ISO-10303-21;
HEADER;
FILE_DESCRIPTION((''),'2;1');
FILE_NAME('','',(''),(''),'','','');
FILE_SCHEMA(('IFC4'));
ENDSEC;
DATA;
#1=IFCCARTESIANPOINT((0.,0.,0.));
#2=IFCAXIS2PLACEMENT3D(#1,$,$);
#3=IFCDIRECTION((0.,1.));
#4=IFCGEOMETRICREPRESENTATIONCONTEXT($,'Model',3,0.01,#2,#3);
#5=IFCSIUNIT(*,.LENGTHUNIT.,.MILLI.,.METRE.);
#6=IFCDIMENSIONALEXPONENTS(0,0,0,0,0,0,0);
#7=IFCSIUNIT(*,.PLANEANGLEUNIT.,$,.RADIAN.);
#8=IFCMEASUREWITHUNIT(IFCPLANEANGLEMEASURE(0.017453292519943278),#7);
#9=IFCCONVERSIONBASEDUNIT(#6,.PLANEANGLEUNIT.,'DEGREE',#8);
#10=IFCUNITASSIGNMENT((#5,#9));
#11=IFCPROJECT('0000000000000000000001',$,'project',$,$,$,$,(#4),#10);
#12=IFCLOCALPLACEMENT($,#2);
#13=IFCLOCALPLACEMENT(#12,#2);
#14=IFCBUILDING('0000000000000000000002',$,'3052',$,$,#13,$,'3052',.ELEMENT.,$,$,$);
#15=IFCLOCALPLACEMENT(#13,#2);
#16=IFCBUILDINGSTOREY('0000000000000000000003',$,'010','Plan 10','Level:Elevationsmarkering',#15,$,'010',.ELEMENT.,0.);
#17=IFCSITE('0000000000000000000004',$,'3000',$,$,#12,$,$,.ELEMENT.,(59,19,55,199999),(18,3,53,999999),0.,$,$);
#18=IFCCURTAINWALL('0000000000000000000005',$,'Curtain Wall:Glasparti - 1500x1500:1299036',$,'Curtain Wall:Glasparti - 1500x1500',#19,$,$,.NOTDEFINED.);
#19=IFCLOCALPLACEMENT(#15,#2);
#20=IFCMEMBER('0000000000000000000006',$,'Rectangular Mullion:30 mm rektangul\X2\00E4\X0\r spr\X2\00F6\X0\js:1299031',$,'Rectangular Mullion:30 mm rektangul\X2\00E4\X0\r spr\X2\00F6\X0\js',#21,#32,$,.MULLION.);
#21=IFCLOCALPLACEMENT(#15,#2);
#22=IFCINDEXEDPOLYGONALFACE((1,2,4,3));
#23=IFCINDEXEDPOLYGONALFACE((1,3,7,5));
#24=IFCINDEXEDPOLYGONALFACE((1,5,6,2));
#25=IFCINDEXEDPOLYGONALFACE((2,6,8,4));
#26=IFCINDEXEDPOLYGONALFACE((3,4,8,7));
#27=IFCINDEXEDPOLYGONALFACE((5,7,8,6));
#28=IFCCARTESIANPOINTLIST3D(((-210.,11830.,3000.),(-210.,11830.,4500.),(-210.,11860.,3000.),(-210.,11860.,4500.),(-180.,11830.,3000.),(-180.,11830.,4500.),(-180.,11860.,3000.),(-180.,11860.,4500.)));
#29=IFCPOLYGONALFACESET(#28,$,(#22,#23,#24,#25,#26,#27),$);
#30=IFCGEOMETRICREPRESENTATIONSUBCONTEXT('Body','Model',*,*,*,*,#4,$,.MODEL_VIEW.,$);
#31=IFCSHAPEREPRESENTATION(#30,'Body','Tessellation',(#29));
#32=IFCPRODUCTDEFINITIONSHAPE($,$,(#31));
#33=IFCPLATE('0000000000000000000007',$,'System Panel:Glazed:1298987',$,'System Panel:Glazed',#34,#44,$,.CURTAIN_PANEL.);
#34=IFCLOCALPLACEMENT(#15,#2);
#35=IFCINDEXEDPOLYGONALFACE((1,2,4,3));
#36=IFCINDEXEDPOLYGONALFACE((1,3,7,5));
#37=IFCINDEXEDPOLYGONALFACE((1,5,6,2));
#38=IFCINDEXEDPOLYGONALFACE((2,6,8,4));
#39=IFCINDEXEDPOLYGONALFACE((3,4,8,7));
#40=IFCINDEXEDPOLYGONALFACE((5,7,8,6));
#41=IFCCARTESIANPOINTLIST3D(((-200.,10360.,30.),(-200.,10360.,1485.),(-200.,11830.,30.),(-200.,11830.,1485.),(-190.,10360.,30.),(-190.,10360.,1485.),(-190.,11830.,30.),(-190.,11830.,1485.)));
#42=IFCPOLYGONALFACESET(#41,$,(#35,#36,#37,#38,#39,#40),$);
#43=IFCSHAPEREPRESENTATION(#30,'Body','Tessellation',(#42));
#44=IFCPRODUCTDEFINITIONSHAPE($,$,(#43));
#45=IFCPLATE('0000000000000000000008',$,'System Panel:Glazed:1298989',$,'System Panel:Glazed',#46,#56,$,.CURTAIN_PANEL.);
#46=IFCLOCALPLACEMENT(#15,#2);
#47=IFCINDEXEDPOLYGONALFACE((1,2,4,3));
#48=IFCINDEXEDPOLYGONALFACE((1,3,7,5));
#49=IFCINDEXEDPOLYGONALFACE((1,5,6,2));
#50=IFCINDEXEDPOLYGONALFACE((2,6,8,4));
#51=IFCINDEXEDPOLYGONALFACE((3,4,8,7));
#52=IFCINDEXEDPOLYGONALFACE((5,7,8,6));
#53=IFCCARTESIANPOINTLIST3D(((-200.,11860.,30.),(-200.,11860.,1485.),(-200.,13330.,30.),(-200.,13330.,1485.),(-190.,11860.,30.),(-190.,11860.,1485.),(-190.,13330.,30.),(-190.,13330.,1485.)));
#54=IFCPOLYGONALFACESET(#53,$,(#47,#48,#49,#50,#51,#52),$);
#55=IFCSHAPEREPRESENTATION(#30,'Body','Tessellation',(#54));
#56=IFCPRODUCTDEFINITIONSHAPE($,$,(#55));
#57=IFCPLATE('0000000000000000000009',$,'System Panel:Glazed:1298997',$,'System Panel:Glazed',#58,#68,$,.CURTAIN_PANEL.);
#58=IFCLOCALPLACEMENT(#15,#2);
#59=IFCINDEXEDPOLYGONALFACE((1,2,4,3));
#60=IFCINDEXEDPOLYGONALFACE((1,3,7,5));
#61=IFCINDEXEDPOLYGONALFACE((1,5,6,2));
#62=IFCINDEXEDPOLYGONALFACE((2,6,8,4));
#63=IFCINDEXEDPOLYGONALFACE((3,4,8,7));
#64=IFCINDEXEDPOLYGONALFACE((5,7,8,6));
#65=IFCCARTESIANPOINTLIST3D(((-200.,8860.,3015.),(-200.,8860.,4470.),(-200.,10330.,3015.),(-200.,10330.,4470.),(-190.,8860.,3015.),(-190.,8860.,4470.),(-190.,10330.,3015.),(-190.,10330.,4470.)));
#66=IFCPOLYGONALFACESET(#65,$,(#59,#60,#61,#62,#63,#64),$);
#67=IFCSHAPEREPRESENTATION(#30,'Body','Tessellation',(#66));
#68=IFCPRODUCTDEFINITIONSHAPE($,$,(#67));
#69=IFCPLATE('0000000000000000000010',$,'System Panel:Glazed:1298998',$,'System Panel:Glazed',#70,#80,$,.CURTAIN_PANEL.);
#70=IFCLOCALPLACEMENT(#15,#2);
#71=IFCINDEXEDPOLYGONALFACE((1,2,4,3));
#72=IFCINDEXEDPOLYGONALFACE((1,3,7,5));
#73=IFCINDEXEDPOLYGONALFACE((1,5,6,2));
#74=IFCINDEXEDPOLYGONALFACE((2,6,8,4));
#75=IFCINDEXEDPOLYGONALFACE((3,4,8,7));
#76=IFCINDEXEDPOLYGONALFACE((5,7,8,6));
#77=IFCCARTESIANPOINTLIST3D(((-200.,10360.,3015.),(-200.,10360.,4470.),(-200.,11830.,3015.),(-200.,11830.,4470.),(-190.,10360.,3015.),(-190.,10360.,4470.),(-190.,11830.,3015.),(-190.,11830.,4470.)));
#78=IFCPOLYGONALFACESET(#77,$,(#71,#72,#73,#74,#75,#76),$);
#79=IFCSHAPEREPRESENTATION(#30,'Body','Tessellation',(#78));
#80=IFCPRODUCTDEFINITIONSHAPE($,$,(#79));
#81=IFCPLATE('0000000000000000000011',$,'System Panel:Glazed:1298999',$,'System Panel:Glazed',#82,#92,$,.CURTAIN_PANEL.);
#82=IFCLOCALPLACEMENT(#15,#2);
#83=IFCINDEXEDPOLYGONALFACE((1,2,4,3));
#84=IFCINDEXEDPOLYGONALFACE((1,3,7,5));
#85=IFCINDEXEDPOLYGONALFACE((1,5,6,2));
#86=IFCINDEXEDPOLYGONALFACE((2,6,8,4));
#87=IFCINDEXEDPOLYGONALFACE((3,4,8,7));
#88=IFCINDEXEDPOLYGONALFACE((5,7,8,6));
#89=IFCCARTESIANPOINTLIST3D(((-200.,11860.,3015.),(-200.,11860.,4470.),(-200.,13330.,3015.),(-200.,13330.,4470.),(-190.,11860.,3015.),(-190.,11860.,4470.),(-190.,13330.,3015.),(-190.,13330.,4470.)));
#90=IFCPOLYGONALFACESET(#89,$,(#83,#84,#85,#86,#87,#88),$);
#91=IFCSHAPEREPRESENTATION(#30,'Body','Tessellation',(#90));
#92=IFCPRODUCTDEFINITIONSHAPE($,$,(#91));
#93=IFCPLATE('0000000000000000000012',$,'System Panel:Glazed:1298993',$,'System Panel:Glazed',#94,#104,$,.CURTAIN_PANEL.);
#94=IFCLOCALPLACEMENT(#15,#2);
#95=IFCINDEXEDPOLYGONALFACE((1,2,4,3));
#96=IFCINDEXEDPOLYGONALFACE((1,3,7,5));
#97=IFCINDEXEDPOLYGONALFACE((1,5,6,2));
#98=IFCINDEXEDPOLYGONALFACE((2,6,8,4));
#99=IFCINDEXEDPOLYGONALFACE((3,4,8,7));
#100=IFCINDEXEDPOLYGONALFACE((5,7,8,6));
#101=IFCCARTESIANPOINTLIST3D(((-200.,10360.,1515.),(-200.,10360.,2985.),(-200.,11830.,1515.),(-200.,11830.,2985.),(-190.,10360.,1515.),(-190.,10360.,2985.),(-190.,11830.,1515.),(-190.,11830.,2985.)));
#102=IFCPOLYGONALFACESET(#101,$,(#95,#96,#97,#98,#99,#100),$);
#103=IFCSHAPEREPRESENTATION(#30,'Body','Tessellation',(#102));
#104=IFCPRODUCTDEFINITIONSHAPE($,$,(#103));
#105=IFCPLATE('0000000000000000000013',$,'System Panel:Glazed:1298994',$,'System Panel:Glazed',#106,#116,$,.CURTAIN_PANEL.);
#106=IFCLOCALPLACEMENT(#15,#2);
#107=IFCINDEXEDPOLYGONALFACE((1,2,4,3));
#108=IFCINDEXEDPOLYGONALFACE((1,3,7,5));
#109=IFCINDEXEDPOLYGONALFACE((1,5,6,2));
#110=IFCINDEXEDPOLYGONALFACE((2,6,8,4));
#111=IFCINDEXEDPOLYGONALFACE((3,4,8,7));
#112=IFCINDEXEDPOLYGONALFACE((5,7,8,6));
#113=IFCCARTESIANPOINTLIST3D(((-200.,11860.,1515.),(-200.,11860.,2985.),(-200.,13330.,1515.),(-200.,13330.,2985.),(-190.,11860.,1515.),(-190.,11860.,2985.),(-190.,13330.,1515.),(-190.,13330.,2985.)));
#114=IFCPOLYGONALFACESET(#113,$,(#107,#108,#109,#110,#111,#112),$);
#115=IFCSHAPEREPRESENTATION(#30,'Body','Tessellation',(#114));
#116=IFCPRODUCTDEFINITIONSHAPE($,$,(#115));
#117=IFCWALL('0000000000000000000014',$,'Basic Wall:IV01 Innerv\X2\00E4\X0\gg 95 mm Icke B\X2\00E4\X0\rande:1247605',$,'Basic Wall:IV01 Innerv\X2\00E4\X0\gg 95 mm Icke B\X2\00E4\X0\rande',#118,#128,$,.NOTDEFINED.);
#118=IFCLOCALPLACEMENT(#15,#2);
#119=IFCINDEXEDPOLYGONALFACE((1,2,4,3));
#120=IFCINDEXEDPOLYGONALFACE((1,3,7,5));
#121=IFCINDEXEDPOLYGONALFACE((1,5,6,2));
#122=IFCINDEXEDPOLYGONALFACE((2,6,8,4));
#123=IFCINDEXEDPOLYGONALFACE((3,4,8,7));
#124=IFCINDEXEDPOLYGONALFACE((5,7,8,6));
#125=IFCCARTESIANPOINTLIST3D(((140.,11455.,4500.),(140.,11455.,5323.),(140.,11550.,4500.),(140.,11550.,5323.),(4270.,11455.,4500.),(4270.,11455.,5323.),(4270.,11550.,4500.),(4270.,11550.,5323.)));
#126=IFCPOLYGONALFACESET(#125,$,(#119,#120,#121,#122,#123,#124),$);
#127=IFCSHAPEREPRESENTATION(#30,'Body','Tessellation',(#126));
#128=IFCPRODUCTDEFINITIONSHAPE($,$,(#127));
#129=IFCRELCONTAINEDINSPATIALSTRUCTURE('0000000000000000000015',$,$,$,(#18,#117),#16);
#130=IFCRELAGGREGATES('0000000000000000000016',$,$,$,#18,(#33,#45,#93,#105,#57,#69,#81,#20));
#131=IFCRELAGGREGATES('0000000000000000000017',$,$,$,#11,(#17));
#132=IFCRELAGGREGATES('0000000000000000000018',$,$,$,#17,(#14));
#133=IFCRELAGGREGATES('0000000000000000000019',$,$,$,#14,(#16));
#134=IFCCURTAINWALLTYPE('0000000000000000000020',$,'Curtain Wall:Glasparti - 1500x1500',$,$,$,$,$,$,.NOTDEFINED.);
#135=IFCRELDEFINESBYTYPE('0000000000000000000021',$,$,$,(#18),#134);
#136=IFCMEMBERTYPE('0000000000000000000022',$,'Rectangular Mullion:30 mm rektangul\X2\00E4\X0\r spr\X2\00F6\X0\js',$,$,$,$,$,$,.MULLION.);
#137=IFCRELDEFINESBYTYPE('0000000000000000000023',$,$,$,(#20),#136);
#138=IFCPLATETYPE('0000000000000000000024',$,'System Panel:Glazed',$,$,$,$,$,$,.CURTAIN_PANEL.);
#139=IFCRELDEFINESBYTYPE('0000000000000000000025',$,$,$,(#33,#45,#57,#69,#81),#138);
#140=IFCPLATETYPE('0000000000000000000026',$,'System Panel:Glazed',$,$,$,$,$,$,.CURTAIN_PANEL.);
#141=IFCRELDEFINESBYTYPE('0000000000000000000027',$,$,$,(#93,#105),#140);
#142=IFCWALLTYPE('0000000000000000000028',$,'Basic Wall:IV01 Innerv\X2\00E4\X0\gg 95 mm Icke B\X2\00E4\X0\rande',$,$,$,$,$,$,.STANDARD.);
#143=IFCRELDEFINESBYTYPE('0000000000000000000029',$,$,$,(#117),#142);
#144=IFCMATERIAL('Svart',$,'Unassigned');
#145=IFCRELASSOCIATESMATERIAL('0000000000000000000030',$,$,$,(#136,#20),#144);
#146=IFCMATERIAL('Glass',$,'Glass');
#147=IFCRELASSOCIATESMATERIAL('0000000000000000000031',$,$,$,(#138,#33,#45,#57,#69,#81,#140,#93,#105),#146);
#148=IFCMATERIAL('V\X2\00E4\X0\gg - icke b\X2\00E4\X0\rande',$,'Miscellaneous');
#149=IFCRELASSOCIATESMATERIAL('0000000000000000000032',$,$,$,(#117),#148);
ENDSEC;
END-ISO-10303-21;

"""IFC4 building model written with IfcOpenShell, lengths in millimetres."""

from ifc_helpers import new_model, entity, si_unit, converted_unit, direction, frame, origin, place, context, subcontext, project, spatial, indexed_curve, outline, extrude, source, transform, mapped, material, type_object, type_shapes, element, aggregate, save


model = new_model("IFC4")

# Units and contexts
model_context = context("Model", 3, precision=0.01, world=origin(), true_north=direction((0.0, 1.0)))
body_context = subcontext(model_context, "Body", "Model", "MODEL_VIEW")
ifc_project = project(units=[si_unit("LENGTHUNIT", "METRE", prefix="MILLI"), converted_unit("PLANEANGLEUNIT", "DEGREE", entity("IfcPlaneAngleMeasure", 0.017453292519943278), si_unit("PLANEANGLEUNIT", "RADIAN"), dimensions=[0, 0, 0, 0, 0, 0, 0])], contexts=[model_context])

# Site, building, storey
site_placement = place(None, origin())
site = spatial("IfcSite", under=ifc_project, at=site_placement, Name="3000", CompositionType="ELEMENT", RefLatitude=(59, 19, 55, 199999), RefLongitude=(18, 3, 53, 999999), RefElevation=0.0)
building_placement = place(site_placement, origin())
building = spatial("IfcBuilding", under=site, at=building_placement, Name="3052", LongName="3052", CompositionType="ELEMENT")
storey_placement = place(building_placement, origin())
storey = spatial("IfcBuildingStorey", under=building, at=storey_placement, Name="010", Description="Plan 10", ObjectType="Level:Elevationsmarkering", LongName="010", CompositionType="ELEMENT", Elevation=0.0)

# Curtain wall, member, plates
curtain_wall_type = type_object("IfcCurtainWallType", Name="Curtain Wall:Glasparti - 1500x1500", PredefinedType="NOTDEFINED")
curtain_wall_placement = place(storey_placement, origin())
curtain_wall = element("IfcCurtainWall", 1, at=curtain_wall_placement, inside=storey, type_object=curtain_wall_type, Name="Curtain Wall:Glasparti - 1500x1500:1299036", ObjectType="Curtain Wall:Glasparti - 1500x1500", PredefinedType="NOTDEFINED")
ifc_material_1 = material(Name="Svart", Category="Unassigned")
member_type_1 = type_object("IfcMemberType", Name="Rectangular Mullion:30 mm rektangulär spröjs", PredefinedType="MULLION", material=ifc_material_1)
shared_shape_1 = source(origin(), body_context, "Body", "SweptSolid", [
    extrude(outline(indexed_curve([(-15.0, -15.0), (15.0, -15.0), (15.0, 15.0), (-15.0, 15.0), (-15.0, -15.0)], self_intersect=False)), frame((0.0, 0.0, -1500.0), z_axis=(0.0, 0.0, 1.0), x_axis=(-1.0, 0.0, 0.0)), (0.0, 0.0, 1.0), 1500.0),
])
type_shapes(member_type_1, [shared_shape_1])
member_1_placement = place(curtain_wall_placement, frame((-195.0, 11845.0, 3000.0), z_axis=(0.0, 0.0, -1.0), x_axis=(0.0, 1.0, 0.0)))
member_1 = element("IfcMember", 2, at=member_1_placement, type_object=member_type_1, material=ifc_material_1, Name="Rectangular Mullion:30 mm rektangulär spröjs:1299031", ObjectType="Rectangular Mullion:30 mm rektangulär spröjs", PredefinedType="MULLION", context=body_context, shape_type="MappedRepresentation", body=[
    mapped(shared_shape_1, transform((0.0, 0.0, 0.0), scale=1.0)),
])
ifc_material_2 = material(Name="Glass", Category="Glass")
plate_type_1 = type_object("IfcPlateType", Name="System Panel:Glazed", PredefinedType="CURTAIN_PANEL", material=ifc_material_2)
shared_shape_2 = source(origin(), body_context, "Body", "SweptSolid", [
    extrude(outline(indexed_curve([(-5.0, -735.0), (5.0, -735.0), (5.0, 735.0), (-5.0, 735.0), (-5.0, -735.0)], self_intersect=False)), frame((0.0, 0.0, 0.0), z_axis=(0.0, 0.0, 1.0), x_axis=(0.0, 1.0, 0.0)), (0.0, 0.0, 1.0), 1455.0),
])
type_shapes(plate_type_1, [shared_shape_2])
plate_1_placement = place(curtain_wall_placement, frame((-195.0, 11095.0, 30.0), z_axis=(0.0, 0.0, 1.0), x_axis=(0.0, 1.0, 0.0)))
plate_1 = element("IfcPlate", 3, at=plate_1_placement, type_object=plate_type_1, material=ifc_material_2, Name="System Panel:Glazed:1298987", ObjectType="System Panel:Glazed", PredefinedType="CURTAIN_PANEL", context=body_context, shape_type="MappedRepresentation", body=[
    mapped(shared_shape_2, transform((0.0, 0.0, 0.0), scale=1.0)),
])
plate_2_placement = place(curtain_wall_placement, frame((-195.0, 12595.0, 30.0), z_axis=(0.0, 0.0, 1.0), x_axis=(0.0, 1.0, 0.0)))
plate_2 = element("IfcPlate", 4, at=plate_2_placement, type_object=plate_type_1, material=ifc_material_2, Name="System Panel:Glazed:1298989", ObjectType="System Panel:Glazed", PredefinedType="CURTAIN_PANEL", context=body_context, shape_type="MappedRepresentation", body=[
    mapped(shared_shape_2, transform((0.0, 0.0, 0.0), scale=1.0)),
])
plate_3_placement = place(curtain_wall_placement, frame((-195.0, 9595.0, 3015.0), z_axis=(0.0, 0.0, 1.0), x_axis=(0.0, 1.0, 0.0)))
plate_3 = element("IfcPlate", 5, at=plate_3_placement, type_object=plate_type_1, material=ifc_material_2, Name="System Panel:Glazed:1298997", ObjectType="System Panel:Glazed", PredefinedType="CURTAIN_PANEL", context=body_context, shape_type="MappedRepresentation", body=[
    mapped(shared_shape_2, transform((0.0, 0.0, 0.0), scale=1.0)),
])
plate_4_placement = place(curtain_wall_placement, frame((-195.0, 11095.0, 3015.0), z_axis=(0.0, 0.0, 1.0), x_axis=(0.0, 1.0, 0.0)))
plate_4 = element("IfcPlate", 6, at=plate_4_placement, type_object=plate_type_1, material=ifc_material_2, Name="System Panel:Glazed:1298998", ObjectType="System Panel:Glazed", PredefinedType="CURTAIN_PANEL", context=body_context, shape_type="MappedRepresentation", body=[
    mapped(shared_shape_2, transform((0.0, 0.0, 0.0), scale=1.0)),
])
plate_5_placement = place(curtain_wall_placement, frame((-195.0, 12595.0, 3015.0), z_axis=(0.0, 0.0, 1.0), x_axis=(0.0, 1.0, 0.0)))
plate_5 = element("IfcPlate", 7, at=plate_5_placement, type_object=plate_type_1, material=ifc_material_2, Name="System Panel:Glazed:1298999", ObjectType="System Panel:Glazed", PredefinedType="CURTAIN_PANEL", context=body_context, shape_type="MappedRepresentation", body=[
    mapped(shared_shape_2, transform((0.0, 0.0, 0.0), scale=1.0)),
])
plate_type_2 = type_object("IfcPlateType", Name="System Panel:Glazed", PredefinedType="CURTAIN_PANEL", material=ifc_material_2)
shared_shape_3 = source(origin(), body_context, "Body", "SweptSolid", [
    extrude(outline(indexed_curve([(-5.0, -735.0), (5.0, -735.0), (5.0, 735.0), (-5.0, 735.0), (-5.0, -735.0)], self_intersect=False)), frame((0.0, 0.0, 0.0), z_axis=(0.0, 0.0, 1.0), x_axis=(0.0, 1.0, 0.0)), (0.0, 0.0, 1.0), 1470.0),
])
type_shapes(plate_type_2, [shared_shape_3])
plate_6_placement = place(curtain_wall_placement, frame((-195.0, 11095.0, 1515.0), z_axis=(0.0, 0.0, 1.0), x_axis=(0.0, 1.0, 0.0)))
plate_6 = element("IfcPlate", 8, at=plate_6_placement, type_object=plate_type_2, material=ifc_material_2, Name="System Panel:Glazed:1298993", ObjectType="System Panel:Glazed", PredefinedType="CURTAIN_PANEL", context=body_context, shape_type="MappedRepresentation", body=[
    mapped(shared_shape_3, transform((0.0, 0.0, 0.0), scale=1.0)),
])
plate_7_placement = place(curtain_wall_placement, frame((-195.0, 12595.0, 1515.0), z_axis=(0.0, 0.0, 1.0), x_axis=(0.0, 1.0, 0.0)))
plate_7 = element("IfcPlate", 9, at=plate_7_placement, type_object=plate_type_2, material=ifc_material_2, Name="System Panel:Glazed:1298994", ObjectType="System Panel:Glazed", PredefinedType="CURTAIN_PANEL", context=body_context, shape_type="MappedRepresentation", body=[
    mapped(shared_shape_3, transform((0.0, 0.0, 0.0), scale=1.0)),
])
aggregate(curtain_wall, [plate_1, plate_2, plate_6, plate_7, plate_3, plate_4, plate_5, member_1])

# Wall
ifc_material_3 = material(Name="Vägg - icke bärande", Category="Miscellaneous")
wall_type = type_object("IfcWallType", Name="Basic Wall:IV01 Innervägg 95 mm Icke Bärande", PredefinedType="STANDARD")
wall_placement = place(storey_placement, frame((140.0, 11502.5, 4500.0)))
element("IfcWall", 10, at=wall_placement, inside=storey, type_object=wall_type, material=ifc_material_3, Name="Basic Wall:IV01 Innervägg 95 mm Icke Bärande:1247605", ObjectType="Basic Wall:IV01 Innervägg 95 mm Icke Bärande", PredefinedType="NOTDEFINED", context=body_context, shape_type="SweptSolid", body=[
    extrude(outline(indexed_curve([(4130.0, 47.5), (0.0, 47.5), (0.0, -47.5), (4130.0, -47.5), (4130.0, 47.5)], self_intersect=False)), origin(), (0.0, 0.0, 1.0), 823.0),
])

save(model, "model.ifc")
